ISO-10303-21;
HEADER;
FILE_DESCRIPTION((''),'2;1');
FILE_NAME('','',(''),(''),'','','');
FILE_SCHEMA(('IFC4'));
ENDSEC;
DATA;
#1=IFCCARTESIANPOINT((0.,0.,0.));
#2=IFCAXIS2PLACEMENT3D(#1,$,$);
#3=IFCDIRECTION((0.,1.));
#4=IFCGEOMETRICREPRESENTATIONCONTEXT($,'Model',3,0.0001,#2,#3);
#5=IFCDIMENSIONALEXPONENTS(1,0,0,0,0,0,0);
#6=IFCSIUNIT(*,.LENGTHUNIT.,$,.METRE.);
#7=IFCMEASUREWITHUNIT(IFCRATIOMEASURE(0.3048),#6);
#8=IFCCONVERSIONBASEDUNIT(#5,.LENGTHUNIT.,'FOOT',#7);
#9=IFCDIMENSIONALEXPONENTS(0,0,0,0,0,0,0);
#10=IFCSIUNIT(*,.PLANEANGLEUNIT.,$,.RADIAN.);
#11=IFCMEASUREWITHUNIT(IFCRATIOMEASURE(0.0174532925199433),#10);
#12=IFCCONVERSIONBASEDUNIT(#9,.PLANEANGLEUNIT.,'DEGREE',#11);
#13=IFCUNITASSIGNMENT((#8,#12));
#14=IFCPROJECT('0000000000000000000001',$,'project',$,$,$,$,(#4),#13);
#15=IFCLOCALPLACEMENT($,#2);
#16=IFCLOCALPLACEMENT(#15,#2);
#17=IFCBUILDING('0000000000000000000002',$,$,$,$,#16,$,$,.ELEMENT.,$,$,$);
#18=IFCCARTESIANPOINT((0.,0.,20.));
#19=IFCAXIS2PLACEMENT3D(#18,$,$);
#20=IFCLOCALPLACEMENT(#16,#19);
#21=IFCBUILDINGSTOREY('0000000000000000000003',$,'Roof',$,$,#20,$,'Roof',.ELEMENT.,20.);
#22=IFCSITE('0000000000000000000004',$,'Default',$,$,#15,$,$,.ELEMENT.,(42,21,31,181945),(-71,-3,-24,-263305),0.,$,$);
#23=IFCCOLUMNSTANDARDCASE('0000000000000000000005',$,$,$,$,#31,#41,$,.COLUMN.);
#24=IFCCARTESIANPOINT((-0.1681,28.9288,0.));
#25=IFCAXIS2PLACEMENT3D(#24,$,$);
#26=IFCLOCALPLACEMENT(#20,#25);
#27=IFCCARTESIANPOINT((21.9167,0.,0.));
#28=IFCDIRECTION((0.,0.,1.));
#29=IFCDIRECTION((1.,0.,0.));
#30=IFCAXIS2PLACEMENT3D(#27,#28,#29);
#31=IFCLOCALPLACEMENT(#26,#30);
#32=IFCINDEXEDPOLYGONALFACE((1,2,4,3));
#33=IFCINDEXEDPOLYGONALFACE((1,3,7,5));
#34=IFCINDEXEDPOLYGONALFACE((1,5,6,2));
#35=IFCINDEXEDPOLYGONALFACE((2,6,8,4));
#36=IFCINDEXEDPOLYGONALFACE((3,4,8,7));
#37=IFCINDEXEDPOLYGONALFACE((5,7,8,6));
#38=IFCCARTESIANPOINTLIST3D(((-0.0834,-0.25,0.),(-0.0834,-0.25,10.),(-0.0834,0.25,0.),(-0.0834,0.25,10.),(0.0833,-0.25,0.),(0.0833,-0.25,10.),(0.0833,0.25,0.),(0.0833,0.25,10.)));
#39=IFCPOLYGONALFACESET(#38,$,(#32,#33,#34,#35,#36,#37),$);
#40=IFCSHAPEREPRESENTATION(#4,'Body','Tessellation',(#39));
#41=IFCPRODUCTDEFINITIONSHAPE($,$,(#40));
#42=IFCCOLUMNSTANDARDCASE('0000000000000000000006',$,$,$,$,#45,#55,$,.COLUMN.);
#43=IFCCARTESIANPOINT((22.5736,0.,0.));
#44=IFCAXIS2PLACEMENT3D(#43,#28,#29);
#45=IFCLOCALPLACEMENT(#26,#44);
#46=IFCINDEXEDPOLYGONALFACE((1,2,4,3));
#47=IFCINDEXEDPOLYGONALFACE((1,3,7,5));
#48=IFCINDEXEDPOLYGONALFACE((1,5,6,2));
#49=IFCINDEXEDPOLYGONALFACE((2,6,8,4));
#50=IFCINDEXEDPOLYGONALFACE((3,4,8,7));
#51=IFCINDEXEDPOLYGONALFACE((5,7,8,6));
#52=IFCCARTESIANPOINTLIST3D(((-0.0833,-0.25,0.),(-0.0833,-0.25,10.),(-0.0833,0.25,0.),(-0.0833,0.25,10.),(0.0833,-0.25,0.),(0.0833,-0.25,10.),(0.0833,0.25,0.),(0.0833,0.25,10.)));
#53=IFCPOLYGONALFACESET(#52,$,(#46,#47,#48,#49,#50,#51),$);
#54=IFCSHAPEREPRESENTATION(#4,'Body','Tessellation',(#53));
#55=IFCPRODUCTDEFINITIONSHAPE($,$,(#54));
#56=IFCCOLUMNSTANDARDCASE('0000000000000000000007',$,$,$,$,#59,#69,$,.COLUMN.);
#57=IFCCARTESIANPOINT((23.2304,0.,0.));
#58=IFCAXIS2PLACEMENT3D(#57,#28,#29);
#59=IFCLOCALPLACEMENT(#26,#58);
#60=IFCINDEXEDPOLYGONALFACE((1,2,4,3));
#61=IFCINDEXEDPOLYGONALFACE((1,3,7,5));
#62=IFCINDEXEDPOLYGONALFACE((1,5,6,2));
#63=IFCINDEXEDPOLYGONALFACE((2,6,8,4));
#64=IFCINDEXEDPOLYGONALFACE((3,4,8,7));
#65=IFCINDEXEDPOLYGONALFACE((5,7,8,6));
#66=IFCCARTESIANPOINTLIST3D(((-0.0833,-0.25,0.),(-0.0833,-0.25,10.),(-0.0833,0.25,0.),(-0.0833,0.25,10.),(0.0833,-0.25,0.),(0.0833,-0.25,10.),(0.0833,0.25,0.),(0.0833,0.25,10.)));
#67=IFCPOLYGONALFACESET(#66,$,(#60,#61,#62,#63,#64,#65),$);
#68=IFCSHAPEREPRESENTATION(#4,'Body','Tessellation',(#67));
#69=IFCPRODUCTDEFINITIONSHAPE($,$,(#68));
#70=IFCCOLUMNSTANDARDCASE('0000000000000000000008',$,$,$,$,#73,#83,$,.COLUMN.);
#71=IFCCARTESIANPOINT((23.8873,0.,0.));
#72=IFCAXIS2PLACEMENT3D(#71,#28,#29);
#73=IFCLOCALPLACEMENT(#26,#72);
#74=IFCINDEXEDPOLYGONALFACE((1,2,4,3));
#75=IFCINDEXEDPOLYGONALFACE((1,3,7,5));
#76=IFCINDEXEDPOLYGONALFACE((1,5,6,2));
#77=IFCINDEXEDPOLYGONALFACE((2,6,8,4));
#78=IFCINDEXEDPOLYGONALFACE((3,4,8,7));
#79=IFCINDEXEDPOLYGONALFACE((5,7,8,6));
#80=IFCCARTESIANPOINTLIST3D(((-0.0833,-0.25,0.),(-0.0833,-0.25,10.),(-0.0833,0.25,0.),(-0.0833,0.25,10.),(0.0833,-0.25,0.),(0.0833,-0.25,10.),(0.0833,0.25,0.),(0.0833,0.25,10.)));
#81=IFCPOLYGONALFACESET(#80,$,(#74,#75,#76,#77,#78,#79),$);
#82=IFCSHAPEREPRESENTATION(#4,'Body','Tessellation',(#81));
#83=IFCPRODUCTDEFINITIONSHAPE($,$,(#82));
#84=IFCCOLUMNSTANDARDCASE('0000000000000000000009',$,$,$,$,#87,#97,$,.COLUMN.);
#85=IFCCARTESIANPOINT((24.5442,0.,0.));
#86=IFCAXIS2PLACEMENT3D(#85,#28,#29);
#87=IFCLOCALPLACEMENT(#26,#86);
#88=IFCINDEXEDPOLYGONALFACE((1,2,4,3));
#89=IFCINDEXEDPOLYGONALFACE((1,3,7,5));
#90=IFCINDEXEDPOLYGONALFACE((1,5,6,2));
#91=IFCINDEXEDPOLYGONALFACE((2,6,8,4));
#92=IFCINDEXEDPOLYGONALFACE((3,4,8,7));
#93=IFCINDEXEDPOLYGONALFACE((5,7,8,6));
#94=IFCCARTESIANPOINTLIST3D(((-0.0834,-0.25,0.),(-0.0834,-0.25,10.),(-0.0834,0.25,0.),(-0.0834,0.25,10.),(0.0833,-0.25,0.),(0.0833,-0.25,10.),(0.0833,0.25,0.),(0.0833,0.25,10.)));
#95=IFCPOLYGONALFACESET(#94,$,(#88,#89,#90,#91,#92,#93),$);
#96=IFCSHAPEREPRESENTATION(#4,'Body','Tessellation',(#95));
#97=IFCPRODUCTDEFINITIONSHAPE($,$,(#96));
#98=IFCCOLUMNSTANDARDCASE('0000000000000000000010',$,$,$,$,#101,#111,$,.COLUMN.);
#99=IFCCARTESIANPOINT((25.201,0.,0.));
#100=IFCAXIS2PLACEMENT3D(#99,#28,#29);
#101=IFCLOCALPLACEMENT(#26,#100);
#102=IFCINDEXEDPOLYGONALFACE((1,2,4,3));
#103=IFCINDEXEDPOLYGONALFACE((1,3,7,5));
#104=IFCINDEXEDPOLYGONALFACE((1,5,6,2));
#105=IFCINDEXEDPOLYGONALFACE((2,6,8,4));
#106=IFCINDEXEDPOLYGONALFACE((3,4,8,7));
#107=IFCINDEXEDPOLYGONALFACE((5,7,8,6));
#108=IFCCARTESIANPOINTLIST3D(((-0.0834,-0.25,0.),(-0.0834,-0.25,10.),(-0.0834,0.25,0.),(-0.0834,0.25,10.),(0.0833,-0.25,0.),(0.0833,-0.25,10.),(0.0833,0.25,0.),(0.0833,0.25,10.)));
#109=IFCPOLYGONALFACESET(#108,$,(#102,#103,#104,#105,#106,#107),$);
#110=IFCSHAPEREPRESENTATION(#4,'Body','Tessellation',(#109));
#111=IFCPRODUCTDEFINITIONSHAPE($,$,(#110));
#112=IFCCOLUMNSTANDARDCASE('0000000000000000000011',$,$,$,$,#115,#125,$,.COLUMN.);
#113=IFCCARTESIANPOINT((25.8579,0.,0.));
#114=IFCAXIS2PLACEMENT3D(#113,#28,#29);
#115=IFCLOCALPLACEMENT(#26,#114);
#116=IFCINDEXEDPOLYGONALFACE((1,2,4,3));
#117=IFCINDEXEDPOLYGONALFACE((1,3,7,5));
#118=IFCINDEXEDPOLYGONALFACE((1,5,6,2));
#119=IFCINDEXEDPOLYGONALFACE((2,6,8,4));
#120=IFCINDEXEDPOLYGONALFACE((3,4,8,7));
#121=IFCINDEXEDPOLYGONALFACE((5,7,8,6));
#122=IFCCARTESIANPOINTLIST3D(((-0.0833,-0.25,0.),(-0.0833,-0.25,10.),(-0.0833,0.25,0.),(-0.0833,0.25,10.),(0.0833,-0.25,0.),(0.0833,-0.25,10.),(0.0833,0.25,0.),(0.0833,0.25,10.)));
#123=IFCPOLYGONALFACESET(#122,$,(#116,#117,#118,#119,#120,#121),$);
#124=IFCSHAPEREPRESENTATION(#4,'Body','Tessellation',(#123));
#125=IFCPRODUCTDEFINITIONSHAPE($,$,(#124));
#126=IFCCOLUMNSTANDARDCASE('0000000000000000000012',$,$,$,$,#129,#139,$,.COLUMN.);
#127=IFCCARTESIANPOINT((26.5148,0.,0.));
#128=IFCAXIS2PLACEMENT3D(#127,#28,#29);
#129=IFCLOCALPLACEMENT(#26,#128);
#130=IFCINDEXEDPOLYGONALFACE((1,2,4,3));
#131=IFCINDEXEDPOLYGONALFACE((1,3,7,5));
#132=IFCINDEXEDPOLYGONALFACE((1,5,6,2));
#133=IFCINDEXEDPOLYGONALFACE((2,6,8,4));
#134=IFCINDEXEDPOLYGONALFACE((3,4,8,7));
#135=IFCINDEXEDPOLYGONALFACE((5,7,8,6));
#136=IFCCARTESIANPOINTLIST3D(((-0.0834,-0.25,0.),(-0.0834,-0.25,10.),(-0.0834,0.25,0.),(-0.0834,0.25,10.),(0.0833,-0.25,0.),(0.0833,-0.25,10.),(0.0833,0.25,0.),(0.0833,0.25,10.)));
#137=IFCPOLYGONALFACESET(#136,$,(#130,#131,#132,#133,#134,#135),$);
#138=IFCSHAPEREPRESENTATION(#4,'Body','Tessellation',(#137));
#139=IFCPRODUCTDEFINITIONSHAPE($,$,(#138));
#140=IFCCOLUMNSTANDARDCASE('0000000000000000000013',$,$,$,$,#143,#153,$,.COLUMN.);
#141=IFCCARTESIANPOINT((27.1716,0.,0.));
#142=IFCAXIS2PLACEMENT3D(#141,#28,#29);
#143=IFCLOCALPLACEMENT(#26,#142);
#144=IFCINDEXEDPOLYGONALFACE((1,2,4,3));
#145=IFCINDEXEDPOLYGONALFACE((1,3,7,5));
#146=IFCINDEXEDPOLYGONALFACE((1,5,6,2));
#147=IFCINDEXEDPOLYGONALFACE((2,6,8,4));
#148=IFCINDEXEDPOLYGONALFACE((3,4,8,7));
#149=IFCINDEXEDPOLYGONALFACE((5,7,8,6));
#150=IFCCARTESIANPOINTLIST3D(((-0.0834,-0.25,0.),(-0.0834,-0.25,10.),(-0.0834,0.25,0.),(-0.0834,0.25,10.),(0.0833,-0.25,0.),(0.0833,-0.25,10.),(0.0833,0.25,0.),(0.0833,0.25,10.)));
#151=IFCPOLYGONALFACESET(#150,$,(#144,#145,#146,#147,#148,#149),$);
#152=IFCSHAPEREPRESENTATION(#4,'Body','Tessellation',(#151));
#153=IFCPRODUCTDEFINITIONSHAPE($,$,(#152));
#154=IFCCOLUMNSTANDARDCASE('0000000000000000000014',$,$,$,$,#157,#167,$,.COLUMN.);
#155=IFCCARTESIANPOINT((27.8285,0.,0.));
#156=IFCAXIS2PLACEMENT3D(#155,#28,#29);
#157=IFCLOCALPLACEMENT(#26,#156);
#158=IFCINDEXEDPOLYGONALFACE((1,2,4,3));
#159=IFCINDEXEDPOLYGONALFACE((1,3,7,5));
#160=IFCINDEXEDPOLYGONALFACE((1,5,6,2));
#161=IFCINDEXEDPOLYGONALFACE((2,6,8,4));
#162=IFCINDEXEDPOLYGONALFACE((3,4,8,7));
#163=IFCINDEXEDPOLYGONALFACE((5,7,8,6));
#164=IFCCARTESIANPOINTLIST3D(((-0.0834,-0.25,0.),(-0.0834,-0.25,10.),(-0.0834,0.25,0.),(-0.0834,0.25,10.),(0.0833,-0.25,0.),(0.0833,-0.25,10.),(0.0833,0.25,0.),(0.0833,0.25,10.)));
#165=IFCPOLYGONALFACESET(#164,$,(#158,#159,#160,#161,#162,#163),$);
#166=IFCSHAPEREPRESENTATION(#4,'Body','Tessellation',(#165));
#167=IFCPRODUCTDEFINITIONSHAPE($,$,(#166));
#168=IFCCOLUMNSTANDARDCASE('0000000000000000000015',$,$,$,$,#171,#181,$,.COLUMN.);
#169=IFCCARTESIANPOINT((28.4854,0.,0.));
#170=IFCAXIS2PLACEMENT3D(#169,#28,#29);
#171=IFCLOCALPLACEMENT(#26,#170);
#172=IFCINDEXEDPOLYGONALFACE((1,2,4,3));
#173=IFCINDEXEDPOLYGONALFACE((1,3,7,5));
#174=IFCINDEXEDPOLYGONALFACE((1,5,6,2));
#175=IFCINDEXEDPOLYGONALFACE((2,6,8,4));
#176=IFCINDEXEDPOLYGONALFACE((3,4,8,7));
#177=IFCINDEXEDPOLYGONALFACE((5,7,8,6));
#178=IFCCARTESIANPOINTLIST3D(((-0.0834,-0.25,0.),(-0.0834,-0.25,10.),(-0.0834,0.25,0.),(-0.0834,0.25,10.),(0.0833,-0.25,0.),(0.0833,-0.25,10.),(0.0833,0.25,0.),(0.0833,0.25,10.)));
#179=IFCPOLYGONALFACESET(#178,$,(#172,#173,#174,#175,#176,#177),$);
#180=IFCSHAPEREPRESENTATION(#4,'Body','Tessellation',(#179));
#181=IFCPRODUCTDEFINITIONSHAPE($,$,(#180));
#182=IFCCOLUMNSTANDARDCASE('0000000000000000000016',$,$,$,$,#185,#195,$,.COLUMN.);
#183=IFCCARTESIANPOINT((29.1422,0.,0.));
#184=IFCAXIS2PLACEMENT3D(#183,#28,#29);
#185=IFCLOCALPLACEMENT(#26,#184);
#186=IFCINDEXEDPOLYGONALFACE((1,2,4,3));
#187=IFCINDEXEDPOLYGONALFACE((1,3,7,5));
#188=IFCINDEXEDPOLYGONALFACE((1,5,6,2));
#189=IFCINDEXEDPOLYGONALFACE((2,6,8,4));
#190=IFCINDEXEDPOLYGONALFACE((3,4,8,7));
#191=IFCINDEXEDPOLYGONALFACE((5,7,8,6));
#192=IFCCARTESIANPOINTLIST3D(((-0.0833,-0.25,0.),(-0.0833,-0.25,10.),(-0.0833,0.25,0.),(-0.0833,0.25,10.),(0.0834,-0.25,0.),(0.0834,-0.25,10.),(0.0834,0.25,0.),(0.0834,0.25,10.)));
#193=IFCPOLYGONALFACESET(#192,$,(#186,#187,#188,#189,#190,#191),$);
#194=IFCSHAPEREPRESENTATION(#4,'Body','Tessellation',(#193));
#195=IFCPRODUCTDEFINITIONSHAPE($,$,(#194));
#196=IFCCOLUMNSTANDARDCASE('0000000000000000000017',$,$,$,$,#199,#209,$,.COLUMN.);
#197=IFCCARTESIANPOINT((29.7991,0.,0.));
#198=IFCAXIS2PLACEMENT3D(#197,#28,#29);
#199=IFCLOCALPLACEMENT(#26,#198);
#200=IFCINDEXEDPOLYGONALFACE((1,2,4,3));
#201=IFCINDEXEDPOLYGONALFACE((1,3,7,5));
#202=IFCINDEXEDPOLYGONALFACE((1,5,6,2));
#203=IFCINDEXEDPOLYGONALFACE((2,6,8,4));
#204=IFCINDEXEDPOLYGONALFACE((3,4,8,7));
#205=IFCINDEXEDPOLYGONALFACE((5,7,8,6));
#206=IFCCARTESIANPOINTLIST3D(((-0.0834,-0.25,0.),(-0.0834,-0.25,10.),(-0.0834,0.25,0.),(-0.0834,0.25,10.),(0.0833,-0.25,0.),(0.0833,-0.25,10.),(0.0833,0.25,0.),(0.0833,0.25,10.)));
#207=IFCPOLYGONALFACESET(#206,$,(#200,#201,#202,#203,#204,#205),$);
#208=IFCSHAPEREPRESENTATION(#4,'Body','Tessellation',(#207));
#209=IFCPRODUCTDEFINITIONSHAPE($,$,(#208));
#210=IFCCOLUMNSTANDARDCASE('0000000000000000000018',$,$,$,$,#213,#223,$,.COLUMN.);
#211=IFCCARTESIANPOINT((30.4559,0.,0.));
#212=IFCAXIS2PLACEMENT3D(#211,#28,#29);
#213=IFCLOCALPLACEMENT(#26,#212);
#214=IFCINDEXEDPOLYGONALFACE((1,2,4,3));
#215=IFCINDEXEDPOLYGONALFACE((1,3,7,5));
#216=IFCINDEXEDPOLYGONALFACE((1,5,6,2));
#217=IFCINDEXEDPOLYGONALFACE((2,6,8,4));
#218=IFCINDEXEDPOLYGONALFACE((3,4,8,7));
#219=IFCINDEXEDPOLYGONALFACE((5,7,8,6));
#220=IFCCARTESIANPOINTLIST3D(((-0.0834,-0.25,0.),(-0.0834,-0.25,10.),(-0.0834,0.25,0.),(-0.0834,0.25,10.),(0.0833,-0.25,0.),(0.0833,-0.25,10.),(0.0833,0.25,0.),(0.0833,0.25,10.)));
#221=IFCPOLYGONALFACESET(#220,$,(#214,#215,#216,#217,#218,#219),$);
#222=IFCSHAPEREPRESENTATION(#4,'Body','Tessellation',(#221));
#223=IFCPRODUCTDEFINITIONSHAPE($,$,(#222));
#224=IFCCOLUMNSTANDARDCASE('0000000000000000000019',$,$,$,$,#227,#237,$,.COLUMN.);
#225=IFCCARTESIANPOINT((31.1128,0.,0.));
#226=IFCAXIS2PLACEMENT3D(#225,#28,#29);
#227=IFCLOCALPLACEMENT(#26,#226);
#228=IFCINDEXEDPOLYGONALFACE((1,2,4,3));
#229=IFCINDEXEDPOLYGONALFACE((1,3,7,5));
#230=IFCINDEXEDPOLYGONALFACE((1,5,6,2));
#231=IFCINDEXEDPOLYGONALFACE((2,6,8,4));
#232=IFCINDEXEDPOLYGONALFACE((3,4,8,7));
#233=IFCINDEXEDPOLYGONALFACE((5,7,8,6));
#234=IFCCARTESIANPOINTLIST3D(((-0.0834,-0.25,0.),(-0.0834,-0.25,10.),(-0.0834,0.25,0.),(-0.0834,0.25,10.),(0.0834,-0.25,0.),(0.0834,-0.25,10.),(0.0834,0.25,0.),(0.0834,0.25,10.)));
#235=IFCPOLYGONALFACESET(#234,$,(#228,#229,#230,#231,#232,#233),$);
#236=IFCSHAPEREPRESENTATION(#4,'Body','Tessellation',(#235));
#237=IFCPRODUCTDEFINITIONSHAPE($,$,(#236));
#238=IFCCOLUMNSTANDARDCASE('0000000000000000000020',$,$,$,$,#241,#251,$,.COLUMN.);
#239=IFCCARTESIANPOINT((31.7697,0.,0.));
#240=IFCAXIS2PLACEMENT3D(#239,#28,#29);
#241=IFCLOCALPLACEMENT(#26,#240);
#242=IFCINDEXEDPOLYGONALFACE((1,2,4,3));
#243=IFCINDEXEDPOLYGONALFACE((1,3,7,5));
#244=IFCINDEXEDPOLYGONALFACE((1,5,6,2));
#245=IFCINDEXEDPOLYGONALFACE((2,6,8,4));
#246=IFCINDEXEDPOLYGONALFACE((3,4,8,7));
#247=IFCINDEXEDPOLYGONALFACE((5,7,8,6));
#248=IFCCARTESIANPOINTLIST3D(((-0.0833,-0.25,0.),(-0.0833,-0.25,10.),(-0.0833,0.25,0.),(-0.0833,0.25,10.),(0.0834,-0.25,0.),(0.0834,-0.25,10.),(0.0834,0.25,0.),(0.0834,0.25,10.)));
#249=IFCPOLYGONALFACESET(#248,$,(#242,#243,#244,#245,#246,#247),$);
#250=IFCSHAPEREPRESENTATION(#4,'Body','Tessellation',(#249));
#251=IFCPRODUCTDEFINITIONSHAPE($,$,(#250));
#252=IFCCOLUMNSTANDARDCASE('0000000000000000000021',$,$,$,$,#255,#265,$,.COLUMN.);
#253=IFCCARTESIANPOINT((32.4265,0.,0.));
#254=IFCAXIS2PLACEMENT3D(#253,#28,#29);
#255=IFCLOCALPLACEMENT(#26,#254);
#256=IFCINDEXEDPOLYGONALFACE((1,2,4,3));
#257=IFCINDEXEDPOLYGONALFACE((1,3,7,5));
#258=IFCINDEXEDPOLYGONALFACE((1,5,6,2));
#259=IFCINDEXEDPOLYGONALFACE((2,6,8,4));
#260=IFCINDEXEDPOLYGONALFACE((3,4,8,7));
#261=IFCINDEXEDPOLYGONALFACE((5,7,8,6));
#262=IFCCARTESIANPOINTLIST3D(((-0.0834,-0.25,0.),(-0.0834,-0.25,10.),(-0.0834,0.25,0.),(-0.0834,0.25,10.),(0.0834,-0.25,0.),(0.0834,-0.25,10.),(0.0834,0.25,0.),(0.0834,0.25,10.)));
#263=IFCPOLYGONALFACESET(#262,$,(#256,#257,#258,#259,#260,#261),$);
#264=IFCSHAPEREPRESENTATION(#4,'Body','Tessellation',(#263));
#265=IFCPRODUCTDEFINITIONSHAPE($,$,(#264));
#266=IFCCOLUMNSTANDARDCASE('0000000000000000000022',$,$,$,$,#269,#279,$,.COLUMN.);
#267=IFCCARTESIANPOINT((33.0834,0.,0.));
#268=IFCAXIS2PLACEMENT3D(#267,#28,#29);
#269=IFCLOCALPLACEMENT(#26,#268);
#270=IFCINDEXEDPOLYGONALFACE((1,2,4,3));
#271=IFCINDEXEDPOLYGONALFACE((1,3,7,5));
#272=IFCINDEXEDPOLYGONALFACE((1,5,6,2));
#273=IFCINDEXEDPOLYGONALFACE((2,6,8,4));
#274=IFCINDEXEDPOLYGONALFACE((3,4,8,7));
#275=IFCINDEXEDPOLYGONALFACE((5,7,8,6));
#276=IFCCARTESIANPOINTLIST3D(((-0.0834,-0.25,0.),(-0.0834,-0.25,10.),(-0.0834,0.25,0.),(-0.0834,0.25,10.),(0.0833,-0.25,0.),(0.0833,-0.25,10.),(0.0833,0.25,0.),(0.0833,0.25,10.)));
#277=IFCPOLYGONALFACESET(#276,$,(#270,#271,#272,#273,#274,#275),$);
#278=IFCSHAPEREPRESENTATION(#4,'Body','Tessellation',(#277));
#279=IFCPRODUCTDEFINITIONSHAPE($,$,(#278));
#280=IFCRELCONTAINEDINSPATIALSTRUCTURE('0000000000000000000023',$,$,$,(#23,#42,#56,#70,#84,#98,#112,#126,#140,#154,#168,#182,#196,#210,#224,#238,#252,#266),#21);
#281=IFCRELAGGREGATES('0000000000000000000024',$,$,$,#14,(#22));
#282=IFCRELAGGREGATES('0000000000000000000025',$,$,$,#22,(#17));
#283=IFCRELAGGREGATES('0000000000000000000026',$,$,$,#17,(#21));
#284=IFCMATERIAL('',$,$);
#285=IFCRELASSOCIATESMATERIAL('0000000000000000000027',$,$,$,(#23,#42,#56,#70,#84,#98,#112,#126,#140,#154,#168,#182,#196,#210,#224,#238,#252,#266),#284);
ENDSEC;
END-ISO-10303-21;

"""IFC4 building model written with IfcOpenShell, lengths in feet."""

from ifc_helpers import new_model, entity, si_unit, converted_unit, direction, frame, origin, place, context, project, spatial, rectangle, extrude, material, element, save


model = new_model("IFC4")

# Units and contexts
model_context = context("Model", 3, precision=0.0001, world=origin(), true_north=direction((0.0, 1.0)))
ifc_project = project(units=[converted_unit("LENGTHUNIT", "FOOT", entity("IfcRatioMeasure", 0.3048), si_unit("LENGTHUNIT", "METRE"), dimensions=[1, 0, 0, 0, 0, 0, 0]), converted_unit("PLANEANGLEUNIT", "DEGREE", entity("IfcRatioMeasure", 0.0174532925199433), si_unit("PLANEANGLEUNIT", "RADIAN"), dimensions=[0, 0, 0, 0, 0, 0, 0])], contexts=[model_context])

# Site, building, storey
site_placement = place(None, origin())
site = spatial("IfcSite", under=ifc_project, at=site_placement, Name="Default", CompositionType="ELEMENT", RefLatitude=(42, 21, 31, 181945), RefLongitude=(-71, -3, -24, -263305), RefElevation=0.0)
building_placement = place(site_placement, origin())
building = spatial("IfcBuilding", under=site, at=building_placement, CompositionType="ELEMENT")
storey_placement = place(building_placement, frame((0.0, 0.0, 20.0)))
storey = spatial("IfcBuildingStorey", under=building, at=storey_placement, Name="Roof", LongName="Roof", CompositionType="ELEMENT", Elevation=20.0)

# Columns
ifc_material_1 = material(Name="")
placement = place(storey_placement, frame((-0.1681, 28.9288, 0.0)))
for number, where, z_axis, x_axis in (
    (1, (21.9167, 0.0, 0.0), (0.0, 0.0, 1.0), (1.0, 0.0, 0.0)),
    (2, (22.5736, 0.0, 0.0), (0.0, 0.0, 1.0), (1.0, 0.0, 0.0)),
    (3, (23.2304, 0.0, 0.0), (0.0, 0.0, 1.0), (1.0, 0.0, 0.0)),
    (4, (23.8873, 0.0, 0.0), (0.0, 0.0, 1.0), (1.0, 0.0, 0.0)),
    (5, (24.5442, 0.0, 0.0), (0.0, 0.0, 1.0), (1.0, 0.0, 0.0)),
    (6, (25.201, 0.0, 0.0), (0.0, 0.0, 1.0), (1.0, 0.0, 0.0)),
    (7, (25.8579, 0.0, 0.0), (0.0, 0.0, 1.0), (1.0, 0.0, 0.0)),
    (8, (26.5148, 0.0, 0.0), (0.0, 0.0, 1.0), (1.0, 0.0, 0.0)),
    (9, (27.1716, 0.0, 0.0), (0.0, 0.0, 1.0), (1.0, 0.0, 0.0)),
    (10, (27.8285, 0.0, 0.0), (0.0, 0.0, 1.0), (1.0, 0.0, 0.0)),
    (11, (28.4854, 0.0, 0.0), (0.0, 0.0, 1.0), (1.0, 0.0, 0.0)),
    (12, (29.1422, 0.0, 0.0), (0.0, 0.0, 1.0), (1.0, 0.0, 0.0)),
    (13, (29.7991, 0.0, 0.0), (0.0, 0.0, 1.0), (1.0, 0.0, 0.0)),
    (14, (30.4559, 0.0, 0.0), (0.0, 0.0, 1.0), (1.0, 0.0, 0.0)),
    (15, (31.1128, 0.0, 0.0), (0.0, 0.0, 1.0), (1.0, 0.0, 0.0)),
    (16, (31.7697, 0.0, 0.0), (0.0, 0.0, 1.0), (1.0, 0.0, 0.0)),
    (17, (32.4265, 0.0, 0.0), (0.0, 0.0, 1.0), (1.0, 0.0, 0.0)),
    (18, (33.0834, 0.0, 0.0), (0.0, 0.0, 1.0), (1.0, 0.0, 0.0)),
):
    element("IfcColumnStandardCase", number, at=place(placement, frame(where, z_axis=z_axis, x_axis=x_axis)), inside=storey, material=ifc_material_1, PredefinedType="COLUMN", context=model_context, shape_type="SweptSolid", body=[
        extrude(rectangle(XDim=0.1667, YDim=0.5), origin(), (0.0, 0.0, 1.0), 10.0),
    ])

save(model, "model.ifc")
